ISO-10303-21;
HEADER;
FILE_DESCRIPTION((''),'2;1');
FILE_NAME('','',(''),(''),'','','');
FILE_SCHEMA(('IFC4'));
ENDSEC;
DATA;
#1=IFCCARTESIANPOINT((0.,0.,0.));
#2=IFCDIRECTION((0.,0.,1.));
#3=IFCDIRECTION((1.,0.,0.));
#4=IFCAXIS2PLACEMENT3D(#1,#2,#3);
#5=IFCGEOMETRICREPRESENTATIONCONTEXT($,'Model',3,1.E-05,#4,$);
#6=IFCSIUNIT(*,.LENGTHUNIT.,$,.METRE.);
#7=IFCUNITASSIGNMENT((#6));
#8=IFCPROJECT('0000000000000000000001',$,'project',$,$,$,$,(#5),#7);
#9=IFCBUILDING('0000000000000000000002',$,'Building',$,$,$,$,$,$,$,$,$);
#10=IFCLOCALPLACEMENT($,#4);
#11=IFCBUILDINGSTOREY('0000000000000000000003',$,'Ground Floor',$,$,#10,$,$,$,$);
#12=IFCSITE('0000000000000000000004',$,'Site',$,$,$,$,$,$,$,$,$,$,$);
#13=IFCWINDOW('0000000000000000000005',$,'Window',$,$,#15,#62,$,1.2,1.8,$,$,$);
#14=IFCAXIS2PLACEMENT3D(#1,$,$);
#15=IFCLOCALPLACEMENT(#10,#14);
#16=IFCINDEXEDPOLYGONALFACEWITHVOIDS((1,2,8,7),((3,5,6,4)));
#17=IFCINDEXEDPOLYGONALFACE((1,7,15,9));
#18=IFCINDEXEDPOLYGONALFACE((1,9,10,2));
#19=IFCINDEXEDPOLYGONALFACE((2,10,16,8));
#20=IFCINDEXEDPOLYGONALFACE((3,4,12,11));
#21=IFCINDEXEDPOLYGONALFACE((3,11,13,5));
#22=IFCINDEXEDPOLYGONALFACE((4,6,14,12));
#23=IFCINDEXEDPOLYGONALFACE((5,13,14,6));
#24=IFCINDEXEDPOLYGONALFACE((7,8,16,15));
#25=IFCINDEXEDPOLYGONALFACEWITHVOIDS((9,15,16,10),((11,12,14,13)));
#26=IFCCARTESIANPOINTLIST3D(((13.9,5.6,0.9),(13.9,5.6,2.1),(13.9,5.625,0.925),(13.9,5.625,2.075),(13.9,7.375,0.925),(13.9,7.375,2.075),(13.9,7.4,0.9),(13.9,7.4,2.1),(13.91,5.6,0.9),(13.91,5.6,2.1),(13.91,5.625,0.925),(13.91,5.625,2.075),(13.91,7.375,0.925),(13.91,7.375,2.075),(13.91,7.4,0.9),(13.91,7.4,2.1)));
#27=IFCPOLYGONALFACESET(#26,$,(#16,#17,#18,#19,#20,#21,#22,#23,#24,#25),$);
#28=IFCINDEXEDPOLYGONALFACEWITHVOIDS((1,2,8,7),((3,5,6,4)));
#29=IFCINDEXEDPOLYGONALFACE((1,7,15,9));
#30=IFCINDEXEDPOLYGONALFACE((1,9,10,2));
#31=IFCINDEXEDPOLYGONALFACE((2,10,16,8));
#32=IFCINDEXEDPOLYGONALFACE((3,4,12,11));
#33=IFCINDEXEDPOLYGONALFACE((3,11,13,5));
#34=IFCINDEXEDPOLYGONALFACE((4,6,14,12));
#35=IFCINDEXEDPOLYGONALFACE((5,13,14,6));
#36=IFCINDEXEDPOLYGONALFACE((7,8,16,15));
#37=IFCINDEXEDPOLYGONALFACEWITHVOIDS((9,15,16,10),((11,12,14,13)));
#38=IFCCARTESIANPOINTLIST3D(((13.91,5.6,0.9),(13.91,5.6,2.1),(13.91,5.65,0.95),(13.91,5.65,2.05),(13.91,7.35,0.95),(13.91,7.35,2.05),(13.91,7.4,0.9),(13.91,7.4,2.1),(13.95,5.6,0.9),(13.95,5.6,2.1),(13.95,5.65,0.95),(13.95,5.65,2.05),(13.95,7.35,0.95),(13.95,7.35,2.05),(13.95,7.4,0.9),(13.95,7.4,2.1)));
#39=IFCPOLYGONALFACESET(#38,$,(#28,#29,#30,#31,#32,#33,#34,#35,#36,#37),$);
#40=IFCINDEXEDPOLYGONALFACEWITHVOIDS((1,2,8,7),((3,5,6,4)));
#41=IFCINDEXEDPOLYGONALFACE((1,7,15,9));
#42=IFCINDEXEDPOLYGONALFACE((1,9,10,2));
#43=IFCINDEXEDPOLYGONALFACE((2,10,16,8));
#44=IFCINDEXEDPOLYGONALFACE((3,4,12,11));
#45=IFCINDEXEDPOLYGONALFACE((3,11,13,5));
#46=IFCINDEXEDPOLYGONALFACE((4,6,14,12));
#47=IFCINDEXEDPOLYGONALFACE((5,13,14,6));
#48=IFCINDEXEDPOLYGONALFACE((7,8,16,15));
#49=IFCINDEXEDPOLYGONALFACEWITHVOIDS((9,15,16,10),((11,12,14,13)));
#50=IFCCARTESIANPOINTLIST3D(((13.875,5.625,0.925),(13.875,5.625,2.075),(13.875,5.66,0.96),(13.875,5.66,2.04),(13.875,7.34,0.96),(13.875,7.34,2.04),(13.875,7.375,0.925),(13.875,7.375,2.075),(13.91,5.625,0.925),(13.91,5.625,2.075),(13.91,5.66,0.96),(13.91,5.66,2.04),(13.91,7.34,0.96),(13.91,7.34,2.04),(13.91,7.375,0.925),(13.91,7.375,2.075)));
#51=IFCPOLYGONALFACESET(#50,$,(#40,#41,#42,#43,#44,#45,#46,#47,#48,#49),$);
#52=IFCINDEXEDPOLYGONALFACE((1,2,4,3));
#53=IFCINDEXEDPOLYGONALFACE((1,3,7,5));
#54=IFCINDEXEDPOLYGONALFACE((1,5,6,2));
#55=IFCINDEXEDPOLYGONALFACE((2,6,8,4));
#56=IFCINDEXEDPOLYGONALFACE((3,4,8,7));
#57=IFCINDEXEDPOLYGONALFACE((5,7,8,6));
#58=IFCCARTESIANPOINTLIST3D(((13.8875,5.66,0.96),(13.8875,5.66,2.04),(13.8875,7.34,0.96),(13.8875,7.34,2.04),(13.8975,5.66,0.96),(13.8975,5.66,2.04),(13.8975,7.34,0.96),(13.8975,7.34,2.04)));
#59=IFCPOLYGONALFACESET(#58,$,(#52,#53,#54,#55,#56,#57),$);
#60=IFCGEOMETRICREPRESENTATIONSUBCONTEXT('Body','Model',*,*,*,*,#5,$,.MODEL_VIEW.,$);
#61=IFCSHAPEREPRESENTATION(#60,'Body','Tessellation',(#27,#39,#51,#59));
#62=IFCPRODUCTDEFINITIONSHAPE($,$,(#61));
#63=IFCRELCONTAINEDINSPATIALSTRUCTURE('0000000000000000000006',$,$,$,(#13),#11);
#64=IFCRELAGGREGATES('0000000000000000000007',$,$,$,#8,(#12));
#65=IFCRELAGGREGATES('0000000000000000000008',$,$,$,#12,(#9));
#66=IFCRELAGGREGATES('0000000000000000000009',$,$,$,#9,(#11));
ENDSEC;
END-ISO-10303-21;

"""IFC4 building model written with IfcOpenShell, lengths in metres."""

from ifc_helpers import new_model, si_unit, frame, origin_with_axes, place, context, subcontext, project, spatial, line, indexed_curve, outline, extrude, element, save


model = new_model("IFC4")

# Units and contexts
model_context = context("Model", 3, precision=1e-05, world=origin_with_axes())
body_context = subcontext(model_context, "Body", "Model", "MODEL_VIEW")
ifc_project = project(units=[si_unit("LENGTHUNIT", "METRE")], contexts=[model_context])

# Site, building, storey
site = spatial("IfcSite", under=ifc_project, Name="Site")
building = spatial("IfcBuilding", under=site, Name="Building")
storey_placement = place(None, origin_with_axes())
storey = spatial("IfcBuildingStorey", under=building, at=storey_placement, Name="Ground Floor")

# Window
window_1_placement = place(storey_placement, frame((14.0, 5.6, 0.9), z_axis=(0.0, 0.0, 1.0), x_axis=(0.0, 1.0, 0.0)))
element("IfcWindow", 1, at=window_1_placement, inside=storey, Name="Window", OverallHeight=1.2, OverallWidth=1.8, context=body_context, shape_type="SweptSolid", body=[
    extrude(outline(indexed_curve([(0.0, 0.0), (1.8, 0.0), (1.8, 1.2), (0.0, 1.2)], segments=[line(1, 2, 3, 4, 1)]), holes=[indexed_curve([(0.025, 0.025), (1.775, 0.025), (1.775, 1.175), (0.025, 1.175)], segments=[line(1, 2, 3, 4, 1)])]), frame((0.0, 0.09, 0.0), z_axis=(0.0, -1.0, 0.0), x_axis=(1.0, 0.0, 0.0)), (0.0, 0.0, -1.0), 0.01),
    extrude(outline(indexed_curve([(0.0, 0.0), (1.8, 0.0), (1.8, 1.2), (0.0, 1.2)], segments=[line(1, 2, 3, 4, 1)]), holes=[indexed_curve([(0.05, 0.05), (1.75, 0.05), (1.75, 1.15), (0.05, 1.15)], segments=[line(1, 2, 3, 4, 1)])]), frame((0.0, 0.05, 0.0), z_axis=(0.0, -1.0, 0.0), x_axis=(1.0, 0.0, 0.0)), (0.0, 0.0, -1.0), 0.04),
    extrude(outline(indexed_curve([(0.0, 0.0), (1.75, 0.0), (1.75, 1.15), (0.0, 1.15)], segments=[line(1, 2, 3, 4, 1)]), holes=[indexed_curve([(0.035, 0.035), (1.715, 0.035), (1.715, 1.115), (0.035, 1.115)], segments=[line(1, 2, 3, 4, 1)])]), frame((0.025, 0.09, 0.025), z_axis=(0.0, -1.0, 0.0), x_axis=(1.0, 0.0, 0.0)), (0.0, 0.0, -1.0), 0.035),
    extrude(outline(indexed_curve([(0.035, 0.035), (1.715, 0.035), (1.715, 1.115), (0.035, 1.115)], segments=[line(1, 2, 3, 4, 1)])), frame((0.025, 0.1025, 0.025), z_axis=(0.0, -1.0, 0.0), x_axis=(1.0, 0.0, 0.0)), (0.0, 0.0, -1.0), 0.01),
])

save(model, "model.ifc")
